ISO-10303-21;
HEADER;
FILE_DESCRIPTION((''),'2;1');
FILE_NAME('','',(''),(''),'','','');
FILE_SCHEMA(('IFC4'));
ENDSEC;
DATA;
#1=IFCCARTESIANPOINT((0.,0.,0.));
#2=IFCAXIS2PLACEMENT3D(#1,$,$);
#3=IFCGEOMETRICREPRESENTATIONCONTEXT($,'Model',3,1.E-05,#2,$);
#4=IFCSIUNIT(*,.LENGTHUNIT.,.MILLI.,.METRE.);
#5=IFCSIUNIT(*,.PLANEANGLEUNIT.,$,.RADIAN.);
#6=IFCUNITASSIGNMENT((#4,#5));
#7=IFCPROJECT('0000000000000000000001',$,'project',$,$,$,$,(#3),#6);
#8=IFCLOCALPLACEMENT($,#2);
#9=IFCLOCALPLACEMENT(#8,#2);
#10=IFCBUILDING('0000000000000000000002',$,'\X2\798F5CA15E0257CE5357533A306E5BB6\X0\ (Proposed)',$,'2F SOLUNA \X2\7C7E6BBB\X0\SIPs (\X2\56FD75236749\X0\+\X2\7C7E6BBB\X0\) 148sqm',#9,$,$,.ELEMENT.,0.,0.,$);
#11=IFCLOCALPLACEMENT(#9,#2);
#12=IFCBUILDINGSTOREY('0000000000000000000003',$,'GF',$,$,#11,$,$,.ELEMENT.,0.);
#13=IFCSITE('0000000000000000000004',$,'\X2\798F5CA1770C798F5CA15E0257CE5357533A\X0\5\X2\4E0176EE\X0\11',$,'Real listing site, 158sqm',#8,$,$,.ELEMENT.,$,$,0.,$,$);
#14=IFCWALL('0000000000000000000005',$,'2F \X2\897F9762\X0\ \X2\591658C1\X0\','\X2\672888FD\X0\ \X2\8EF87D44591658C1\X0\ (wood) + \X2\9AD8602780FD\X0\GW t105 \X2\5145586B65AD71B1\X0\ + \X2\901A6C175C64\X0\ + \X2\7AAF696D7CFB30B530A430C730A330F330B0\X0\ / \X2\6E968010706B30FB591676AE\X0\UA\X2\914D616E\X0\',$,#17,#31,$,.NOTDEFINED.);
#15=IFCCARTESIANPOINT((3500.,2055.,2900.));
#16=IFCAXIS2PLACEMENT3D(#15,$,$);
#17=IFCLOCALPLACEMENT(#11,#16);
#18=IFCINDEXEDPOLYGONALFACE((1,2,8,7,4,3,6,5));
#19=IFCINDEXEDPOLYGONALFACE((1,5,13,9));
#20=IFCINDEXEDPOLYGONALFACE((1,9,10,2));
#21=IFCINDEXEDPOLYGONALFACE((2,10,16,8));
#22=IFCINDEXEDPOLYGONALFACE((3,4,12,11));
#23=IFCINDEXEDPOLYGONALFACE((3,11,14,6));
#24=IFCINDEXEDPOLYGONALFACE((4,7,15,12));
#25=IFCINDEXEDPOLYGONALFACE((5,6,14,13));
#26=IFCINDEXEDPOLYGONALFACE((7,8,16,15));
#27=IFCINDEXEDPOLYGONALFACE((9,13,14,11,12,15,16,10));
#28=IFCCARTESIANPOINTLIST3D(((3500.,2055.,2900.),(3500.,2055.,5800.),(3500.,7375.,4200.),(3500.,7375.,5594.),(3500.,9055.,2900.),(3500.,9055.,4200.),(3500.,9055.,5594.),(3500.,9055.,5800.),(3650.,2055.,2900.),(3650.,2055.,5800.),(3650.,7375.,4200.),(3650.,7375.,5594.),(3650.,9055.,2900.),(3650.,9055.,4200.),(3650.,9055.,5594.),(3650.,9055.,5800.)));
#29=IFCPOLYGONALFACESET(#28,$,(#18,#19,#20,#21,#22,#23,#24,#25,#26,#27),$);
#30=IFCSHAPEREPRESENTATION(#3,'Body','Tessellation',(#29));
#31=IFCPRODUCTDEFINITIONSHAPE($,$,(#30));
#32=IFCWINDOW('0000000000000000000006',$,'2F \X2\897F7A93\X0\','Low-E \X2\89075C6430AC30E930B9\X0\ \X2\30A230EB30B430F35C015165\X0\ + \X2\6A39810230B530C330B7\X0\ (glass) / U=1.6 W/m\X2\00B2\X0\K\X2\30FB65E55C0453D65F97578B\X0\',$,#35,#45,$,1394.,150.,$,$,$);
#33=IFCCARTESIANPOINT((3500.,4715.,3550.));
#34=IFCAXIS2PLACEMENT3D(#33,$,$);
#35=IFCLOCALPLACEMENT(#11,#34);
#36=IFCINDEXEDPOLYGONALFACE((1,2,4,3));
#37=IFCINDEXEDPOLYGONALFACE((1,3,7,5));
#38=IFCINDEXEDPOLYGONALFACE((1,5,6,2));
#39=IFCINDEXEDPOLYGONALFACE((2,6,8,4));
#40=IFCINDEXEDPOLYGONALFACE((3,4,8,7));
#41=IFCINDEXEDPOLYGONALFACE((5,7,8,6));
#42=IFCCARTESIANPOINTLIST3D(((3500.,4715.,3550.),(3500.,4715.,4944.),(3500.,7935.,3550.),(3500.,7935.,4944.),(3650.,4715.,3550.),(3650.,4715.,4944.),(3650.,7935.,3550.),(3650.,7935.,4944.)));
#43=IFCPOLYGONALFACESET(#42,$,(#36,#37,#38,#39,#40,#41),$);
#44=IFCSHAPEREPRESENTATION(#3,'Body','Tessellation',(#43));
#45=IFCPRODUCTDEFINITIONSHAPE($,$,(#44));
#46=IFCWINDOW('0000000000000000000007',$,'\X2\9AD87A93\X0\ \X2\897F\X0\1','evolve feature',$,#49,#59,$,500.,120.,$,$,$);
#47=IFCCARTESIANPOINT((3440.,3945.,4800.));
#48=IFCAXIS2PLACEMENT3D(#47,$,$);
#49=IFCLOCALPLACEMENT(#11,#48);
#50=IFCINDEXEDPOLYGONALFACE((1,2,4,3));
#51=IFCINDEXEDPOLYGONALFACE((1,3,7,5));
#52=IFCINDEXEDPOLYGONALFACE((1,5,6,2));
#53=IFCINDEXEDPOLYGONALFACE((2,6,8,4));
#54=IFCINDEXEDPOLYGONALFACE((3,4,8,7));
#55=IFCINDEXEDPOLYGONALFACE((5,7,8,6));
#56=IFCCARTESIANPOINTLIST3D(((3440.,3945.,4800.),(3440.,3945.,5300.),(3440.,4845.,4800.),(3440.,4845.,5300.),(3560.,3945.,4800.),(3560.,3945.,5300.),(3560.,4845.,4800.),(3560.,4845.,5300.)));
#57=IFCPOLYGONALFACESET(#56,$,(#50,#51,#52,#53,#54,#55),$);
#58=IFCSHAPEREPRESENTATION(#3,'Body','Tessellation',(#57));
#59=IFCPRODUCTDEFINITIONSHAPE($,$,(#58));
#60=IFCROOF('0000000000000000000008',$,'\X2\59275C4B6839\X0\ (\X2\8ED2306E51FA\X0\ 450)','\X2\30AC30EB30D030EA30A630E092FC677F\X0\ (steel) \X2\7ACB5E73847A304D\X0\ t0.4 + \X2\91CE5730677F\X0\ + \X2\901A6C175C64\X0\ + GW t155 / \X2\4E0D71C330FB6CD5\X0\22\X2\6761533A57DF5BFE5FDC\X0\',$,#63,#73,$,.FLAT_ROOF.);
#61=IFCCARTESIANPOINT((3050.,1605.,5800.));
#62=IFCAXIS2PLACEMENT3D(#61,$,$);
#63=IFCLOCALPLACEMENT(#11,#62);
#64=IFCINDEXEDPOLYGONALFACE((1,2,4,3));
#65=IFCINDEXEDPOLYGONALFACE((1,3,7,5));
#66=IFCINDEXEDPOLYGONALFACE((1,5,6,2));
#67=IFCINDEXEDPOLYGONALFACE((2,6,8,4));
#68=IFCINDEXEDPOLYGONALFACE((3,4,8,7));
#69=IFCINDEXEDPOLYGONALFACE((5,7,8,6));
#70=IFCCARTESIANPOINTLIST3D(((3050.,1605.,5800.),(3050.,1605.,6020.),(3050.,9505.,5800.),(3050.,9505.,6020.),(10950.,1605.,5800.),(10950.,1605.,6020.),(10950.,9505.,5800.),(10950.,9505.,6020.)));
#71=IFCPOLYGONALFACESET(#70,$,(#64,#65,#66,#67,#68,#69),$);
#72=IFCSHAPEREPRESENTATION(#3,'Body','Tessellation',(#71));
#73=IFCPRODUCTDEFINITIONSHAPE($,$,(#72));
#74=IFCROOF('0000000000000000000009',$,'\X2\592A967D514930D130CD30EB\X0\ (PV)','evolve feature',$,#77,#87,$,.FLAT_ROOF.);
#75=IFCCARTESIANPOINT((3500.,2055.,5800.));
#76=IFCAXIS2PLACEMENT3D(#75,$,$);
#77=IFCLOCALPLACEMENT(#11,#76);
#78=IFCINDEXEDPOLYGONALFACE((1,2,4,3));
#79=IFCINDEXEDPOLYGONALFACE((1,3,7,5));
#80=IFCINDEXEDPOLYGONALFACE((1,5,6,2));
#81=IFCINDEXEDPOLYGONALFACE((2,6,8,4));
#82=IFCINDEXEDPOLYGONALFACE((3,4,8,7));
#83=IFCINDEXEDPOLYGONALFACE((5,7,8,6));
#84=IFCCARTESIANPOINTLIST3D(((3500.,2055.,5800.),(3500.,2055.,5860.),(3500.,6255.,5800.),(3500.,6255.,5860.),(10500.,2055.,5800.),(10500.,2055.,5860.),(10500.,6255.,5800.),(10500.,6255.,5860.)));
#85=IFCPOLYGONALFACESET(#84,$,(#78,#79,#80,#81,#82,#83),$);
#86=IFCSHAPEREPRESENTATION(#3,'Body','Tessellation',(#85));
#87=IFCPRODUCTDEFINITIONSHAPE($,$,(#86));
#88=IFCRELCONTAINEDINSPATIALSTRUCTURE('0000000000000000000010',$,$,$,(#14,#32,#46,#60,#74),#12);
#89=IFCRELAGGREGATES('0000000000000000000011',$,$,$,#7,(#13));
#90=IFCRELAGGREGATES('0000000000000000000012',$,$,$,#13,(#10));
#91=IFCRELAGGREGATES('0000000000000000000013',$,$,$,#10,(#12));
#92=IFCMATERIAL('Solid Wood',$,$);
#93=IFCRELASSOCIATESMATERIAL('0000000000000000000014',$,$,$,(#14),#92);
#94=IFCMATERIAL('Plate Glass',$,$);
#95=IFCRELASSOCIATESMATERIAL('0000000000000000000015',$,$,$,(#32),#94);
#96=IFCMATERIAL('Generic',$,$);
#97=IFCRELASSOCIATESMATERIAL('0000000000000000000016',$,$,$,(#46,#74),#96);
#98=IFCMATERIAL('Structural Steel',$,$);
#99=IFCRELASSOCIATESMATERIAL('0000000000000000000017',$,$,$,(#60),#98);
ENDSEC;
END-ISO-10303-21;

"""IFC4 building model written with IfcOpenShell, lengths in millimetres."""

from ifc_helpers import new_model, si_unit, frame, frame_2d, origin, place, context, project, spatial, rectangle, extrude, material, element, fill, save


model = new_model("IFC4")

# Units and contexts
model_context = context("Model", 3, precision=1e-05, world=origin())
ifc_project = project(units=[si_unit("LENGTHUNIT", "METRE", prefix="MILLI"), si_unit("PLANEANGLEUNIT", "RADIAN")], contexts=[model_context])

# Site, building, storey
site_placement = place(None, origin())
site = spatial("IfcSite", under=ifc_project, at=site_placement, Name="福岡県福岡市城南区5丁目11", ObjectType="Real listing site, 158sqm", CompositionType="ELEMENT", RefElevation=0.0)
building_placement = place(site_placement, origin())
building = spatial("IfcBuilding", under=site, at=building_placement, Name="福岡市城南区の家 (Proposed)", ObjectType="2F SOLUNA 籾殻SIPs (国産杉+籾殻) 148sqm", CompositionType="ELEMENT", ElevationOfRefHeight=0.0, ElevationOfTerrain=0.0)
storey_placement = place(building_placement, origin())
storey = spatial("IfcBuildingStorey", under=building, at=storey_placement, Name="GF", CompositionType="ELEMENT", Elevation=0.0)

# Shared definitions
ifc_material_1 = material(Name="Solid Wood")
ifc_material_2 = material(Name="Generic")

# Shared definitions
ifc_material_3 = material(Name="Plate Glass")

# Wall, openings, windows
wall_1_placement = place(storey_placement, frame((3500.0, 2055.0, 2900.0)))
wall_1 = element("IfcWall", 1, at=wall_1_placement, inside=storey, material=ifc_material_1, Name="2F 西面 外壁", Description="木製 軸組外壁 (wood) + 高性能GW t105 充填断熱 + 通気層 + 窯業系サイディング / 準耐火・外皮UA配慮", PredefinedType="NOTDEFINED", context=model_context, shape_type="SweptSolid", body=[
    extrude(rectangle(XDim=150.0, YDim=7000.0, at=frame_2d((75.0, 3500.0))), frame((3500.0, 2055.0, 2900.0)), (0.0, 0.0, 1.0), 2900.0),
])
opening_1_placement = place(storey_placement, frame((3500.0, 4715.0, 3550.0)))
opening_1 = element("IfcOpeningElement", 2, at=opening_1_placement, cuts=wall_1, PredefinedType="NOTDEFINED", context=model_context, shape_type="SweptSolid", body=[
    extrude(rectangle(XDim=150.0, YDim=3220.0, at=frame_2d((75.0, 1610.0))), frame((3500.0, 4715.0, 3550.0)), (0.0, 0.0, 1.0), 1394.0),
])
opening_2_placement = place(storey_placement, frame((3440.0, 3945.0, 4800.0)))
opening_2 = element("IfcOpeningElement", 3, at=opening_2_placement, cuts=wall_1, PredefinedType="NOTDEFINED", context=model_context, shape_type="SweptSolid", body=[
    extrude(rectangle(XDim=120.0, YDim=900.0, at=frame_2d((60.0, 450.0))), frame((3440.0, 3945.0, 4800.0)), (0.0, 0.0, 1.0), 500.0),
])
window_1_placement = place(storey_placement, frame((3500.0, 4715.0, 3550.0)))
window_1 = element("IfcWindow", 4, at=window_1_placement, inside=storey, material=ifc_material_3, Name="2F 西窓", Description="Low-E 複層ガラス アルゴン封入 + 樹脂サッシ (glass) / U=1.6 W/m²K・日射取得型", OverallHeight=1394.0, OverallWidth=150.0, context=model_context, shape_type="SweptSolid", body=[
    extrude(rectangle(XDim=150.0, YDim=3220.0, at=frame_2d((75.0, 1610.0))), frame((3500.0, 4715.0, 3550.0)), (0.0, 0.0, 1.0), 1394.0),
])
fill(opening_1, window_1)
window_2_placement = place(storey_placement, frame((3440.0, 3945.0, 4800.0)))
window_2 = element("IfcWindow", 5, at=window_2_placement, inside=storey, material=ifc_material_2, Name="高窓 西1", Description="evolve feature", OverallHeight=500.0, OverallWidth=120.0, context=model_context, shape_type="SweptSolid", body=[
    extrude(rectangle(XDim=120.0, YDim=900.0, at=frame_2d((60.0, 450.0))), frame((3440.0, 3945.0, 4800.0)), (0.0, 0.0, 1.0), 500.0),
])
fill(opening_2, window_2)

# Roofs
ifc_material_4 = material(Name="Structural Steel")
roof_1_placement = place(storey_placement, frame((3050.0, 1605.0, 5800.0)))
element("IfcRoof", 6, at=roof_1_placement, inside=storey, material=ifc_material_4, Name="大屋根 (軒の出 450)", Description="ガルバリウム鋼板 (steel) 立平葺き t0.4 + 野地板 + 通気層 + GW t155 / 不燃・法22条区域対応", PredefinedType="FLAT_ROOF", context=model_context, shape_type="SweptSolid", body=[
    extrude(rectangle(XDim=7900.0, YDim=7900.0, at=frame_2d((3950.0, 3950.0))), frame((3050.0, 1605.0, 5800.0)), (0.0, 0.0, 1.0), 220.0),
])
roof_2_placement = place(storey_placement, frame((3500.0, 2055.0, 5800.0)))
element("IfcRoof", 7, at=roof_2_placement, inside=storey, material=ifc_material_2, Name="太陽光パネル (PV)", Description="evolve feature", PredefinedType="FLAT_ROOF", context=model_context, shape_type="SweptSolid", body=[
    extrude(rectangle(XDim=7000.0, YDim=4200.0, at=frame_2d((3500.0, 2100.0))), frame((3500.0, 2055.0, 5800.0)), (0.0, 0.0, 1.0), 60.0),
])

save(model, "model.ifc")
